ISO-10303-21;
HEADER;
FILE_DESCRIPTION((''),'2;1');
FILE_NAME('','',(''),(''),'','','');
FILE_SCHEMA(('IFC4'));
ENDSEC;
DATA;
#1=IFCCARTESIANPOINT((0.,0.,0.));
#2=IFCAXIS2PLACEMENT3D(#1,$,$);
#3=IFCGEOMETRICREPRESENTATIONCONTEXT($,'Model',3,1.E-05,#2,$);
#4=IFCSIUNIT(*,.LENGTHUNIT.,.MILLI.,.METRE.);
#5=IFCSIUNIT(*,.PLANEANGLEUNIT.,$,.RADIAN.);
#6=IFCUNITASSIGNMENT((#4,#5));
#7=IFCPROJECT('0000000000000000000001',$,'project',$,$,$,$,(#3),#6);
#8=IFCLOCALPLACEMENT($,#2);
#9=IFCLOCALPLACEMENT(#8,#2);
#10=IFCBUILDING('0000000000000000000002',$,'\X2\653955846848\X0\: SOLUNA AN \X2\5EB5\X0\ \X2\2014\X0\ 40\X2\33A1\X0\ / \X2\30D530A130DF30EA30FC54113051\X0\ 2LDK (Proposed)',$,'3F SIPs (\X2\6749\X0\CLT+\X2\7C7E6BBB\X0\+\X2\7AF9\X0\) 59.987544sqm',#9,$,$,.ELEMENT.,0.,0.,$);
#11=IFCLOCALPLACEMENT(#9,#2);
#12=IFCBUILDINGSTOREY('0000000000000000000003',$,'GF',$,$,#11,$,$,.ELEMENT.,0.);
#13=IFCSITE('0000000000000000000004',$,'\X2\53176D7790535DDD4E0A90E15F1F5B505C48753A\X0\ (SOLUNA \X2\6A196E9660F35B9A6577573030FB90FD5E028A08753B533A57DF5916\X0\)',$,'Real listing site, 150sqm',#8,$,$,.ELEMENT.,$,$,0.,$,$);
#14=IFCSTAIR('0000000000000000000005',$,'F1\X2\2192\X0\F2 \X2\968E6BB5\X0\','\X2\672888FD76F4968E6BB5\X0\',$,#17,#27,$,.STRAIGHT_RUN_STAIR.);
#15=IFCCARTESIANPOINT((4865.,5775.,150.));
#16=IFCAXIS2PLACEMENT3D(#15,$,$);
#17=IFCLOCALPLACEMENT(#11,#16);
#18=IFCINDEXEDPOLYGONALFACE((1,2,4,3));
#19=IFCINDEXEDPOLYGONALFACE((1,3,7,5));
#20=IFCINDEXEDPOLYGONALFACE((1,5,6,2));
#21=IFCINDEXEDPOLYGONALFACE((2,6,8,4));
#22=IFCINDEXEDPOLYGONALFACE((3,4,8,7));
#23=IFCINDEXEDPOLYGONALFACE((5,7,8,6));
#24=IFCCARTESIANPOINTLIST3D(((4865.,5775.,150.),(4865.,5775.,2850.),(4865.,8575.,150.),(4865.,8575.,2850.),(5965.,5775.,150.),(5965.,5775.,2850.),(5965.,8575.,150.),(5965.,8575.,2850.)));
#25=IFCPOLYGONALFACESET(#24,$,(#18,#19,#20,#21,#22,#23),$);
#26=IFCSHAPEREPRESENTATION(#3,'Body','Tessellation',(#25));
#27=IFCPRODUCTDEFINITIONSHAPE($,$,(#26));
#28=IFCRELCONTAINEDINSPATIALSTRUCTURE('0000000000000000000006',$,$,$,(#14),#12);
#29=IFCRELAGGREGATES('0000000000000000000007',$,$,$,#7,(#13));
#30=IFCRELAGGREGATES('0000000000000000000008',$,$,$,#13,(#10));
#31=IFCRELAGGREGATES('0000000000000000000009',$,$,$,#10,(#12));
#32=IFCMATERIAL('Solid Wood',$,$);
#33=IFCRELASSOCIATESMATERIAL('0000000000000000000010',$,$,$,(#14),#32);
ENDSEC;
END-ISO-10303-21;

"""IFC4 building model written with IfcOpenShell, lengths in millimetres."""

from ifc_helpers import new_model, si_unit, frame, frame_2d, origin, place, context, project, spatial, rectangle, extrude, material, element, save


model = new_model("IFC4")

# Units and contexts
model_context = context("Model", 3, precision=1e-05, world=origin())
ifc_project = project(units=[si_unit("LENGTHUNIT", "METRE", prefix="MILLI"), si_unit("PLANEANGLEUNIT", "RADIAN")], contexts=[model_context])

# Site, building, storey
site_placement = place(None, origin())
site = spatial("IfcSite", under=ifc_project, at=site_placement, Name="北海道川上郡弟子屈町 (SOLUNA 標準想定敷地・都市計画区域外)", ObjectType="Real listing site, 150sqm", CompositionType="ELEMENT", RefElevation=0.0)
building_placement = place(site_placement, origin())
building = spatial("IfcBuilding", under=site, at=building_placement, Name="改善案: SOLUNA AN 庵 — 40㎡ / ファミリー向け 2LDK (Proposed)", ObjectType="3F SIPs (杉CLT+籾殻+竹) 59.987544sqm", CompositionType="ELEMENT", ElevationOfRefHeight=0.0, ElevationOfTerrain=0.0)
storey_placement = place(building_placement, origin())
storey = spatial("IfcBuildingStorey", under=building, at=storey_placement, Name="GF", CompositionType="ELEMENT", Elevation=0.0)

# Shared definitions
ifc_material_1 = material(Name="Solid Wood")

# Stair
stair_placement = place(storey_placement, frame((4865.0, 5775.0, 150.0)))
element("IfcStair", 1, at=stair_placement, inside=storey, material=ifc_material_1, Name="F1→F2 階段", Description="木製直階段", PredefinedType="STRAIGHT_RUN_STAIR", context=model_context, shape_type="SweptSolid", body=[
    extrude(rectangle(XDim=1100.0, YDim=2800.0, at=frame_2d((550.0, 1400.0))), frame((4865.0, 5775.0, 150.0)), (0.0, 0.0, 1.0), 2700.0),
])

save(model, "model.ifc")
